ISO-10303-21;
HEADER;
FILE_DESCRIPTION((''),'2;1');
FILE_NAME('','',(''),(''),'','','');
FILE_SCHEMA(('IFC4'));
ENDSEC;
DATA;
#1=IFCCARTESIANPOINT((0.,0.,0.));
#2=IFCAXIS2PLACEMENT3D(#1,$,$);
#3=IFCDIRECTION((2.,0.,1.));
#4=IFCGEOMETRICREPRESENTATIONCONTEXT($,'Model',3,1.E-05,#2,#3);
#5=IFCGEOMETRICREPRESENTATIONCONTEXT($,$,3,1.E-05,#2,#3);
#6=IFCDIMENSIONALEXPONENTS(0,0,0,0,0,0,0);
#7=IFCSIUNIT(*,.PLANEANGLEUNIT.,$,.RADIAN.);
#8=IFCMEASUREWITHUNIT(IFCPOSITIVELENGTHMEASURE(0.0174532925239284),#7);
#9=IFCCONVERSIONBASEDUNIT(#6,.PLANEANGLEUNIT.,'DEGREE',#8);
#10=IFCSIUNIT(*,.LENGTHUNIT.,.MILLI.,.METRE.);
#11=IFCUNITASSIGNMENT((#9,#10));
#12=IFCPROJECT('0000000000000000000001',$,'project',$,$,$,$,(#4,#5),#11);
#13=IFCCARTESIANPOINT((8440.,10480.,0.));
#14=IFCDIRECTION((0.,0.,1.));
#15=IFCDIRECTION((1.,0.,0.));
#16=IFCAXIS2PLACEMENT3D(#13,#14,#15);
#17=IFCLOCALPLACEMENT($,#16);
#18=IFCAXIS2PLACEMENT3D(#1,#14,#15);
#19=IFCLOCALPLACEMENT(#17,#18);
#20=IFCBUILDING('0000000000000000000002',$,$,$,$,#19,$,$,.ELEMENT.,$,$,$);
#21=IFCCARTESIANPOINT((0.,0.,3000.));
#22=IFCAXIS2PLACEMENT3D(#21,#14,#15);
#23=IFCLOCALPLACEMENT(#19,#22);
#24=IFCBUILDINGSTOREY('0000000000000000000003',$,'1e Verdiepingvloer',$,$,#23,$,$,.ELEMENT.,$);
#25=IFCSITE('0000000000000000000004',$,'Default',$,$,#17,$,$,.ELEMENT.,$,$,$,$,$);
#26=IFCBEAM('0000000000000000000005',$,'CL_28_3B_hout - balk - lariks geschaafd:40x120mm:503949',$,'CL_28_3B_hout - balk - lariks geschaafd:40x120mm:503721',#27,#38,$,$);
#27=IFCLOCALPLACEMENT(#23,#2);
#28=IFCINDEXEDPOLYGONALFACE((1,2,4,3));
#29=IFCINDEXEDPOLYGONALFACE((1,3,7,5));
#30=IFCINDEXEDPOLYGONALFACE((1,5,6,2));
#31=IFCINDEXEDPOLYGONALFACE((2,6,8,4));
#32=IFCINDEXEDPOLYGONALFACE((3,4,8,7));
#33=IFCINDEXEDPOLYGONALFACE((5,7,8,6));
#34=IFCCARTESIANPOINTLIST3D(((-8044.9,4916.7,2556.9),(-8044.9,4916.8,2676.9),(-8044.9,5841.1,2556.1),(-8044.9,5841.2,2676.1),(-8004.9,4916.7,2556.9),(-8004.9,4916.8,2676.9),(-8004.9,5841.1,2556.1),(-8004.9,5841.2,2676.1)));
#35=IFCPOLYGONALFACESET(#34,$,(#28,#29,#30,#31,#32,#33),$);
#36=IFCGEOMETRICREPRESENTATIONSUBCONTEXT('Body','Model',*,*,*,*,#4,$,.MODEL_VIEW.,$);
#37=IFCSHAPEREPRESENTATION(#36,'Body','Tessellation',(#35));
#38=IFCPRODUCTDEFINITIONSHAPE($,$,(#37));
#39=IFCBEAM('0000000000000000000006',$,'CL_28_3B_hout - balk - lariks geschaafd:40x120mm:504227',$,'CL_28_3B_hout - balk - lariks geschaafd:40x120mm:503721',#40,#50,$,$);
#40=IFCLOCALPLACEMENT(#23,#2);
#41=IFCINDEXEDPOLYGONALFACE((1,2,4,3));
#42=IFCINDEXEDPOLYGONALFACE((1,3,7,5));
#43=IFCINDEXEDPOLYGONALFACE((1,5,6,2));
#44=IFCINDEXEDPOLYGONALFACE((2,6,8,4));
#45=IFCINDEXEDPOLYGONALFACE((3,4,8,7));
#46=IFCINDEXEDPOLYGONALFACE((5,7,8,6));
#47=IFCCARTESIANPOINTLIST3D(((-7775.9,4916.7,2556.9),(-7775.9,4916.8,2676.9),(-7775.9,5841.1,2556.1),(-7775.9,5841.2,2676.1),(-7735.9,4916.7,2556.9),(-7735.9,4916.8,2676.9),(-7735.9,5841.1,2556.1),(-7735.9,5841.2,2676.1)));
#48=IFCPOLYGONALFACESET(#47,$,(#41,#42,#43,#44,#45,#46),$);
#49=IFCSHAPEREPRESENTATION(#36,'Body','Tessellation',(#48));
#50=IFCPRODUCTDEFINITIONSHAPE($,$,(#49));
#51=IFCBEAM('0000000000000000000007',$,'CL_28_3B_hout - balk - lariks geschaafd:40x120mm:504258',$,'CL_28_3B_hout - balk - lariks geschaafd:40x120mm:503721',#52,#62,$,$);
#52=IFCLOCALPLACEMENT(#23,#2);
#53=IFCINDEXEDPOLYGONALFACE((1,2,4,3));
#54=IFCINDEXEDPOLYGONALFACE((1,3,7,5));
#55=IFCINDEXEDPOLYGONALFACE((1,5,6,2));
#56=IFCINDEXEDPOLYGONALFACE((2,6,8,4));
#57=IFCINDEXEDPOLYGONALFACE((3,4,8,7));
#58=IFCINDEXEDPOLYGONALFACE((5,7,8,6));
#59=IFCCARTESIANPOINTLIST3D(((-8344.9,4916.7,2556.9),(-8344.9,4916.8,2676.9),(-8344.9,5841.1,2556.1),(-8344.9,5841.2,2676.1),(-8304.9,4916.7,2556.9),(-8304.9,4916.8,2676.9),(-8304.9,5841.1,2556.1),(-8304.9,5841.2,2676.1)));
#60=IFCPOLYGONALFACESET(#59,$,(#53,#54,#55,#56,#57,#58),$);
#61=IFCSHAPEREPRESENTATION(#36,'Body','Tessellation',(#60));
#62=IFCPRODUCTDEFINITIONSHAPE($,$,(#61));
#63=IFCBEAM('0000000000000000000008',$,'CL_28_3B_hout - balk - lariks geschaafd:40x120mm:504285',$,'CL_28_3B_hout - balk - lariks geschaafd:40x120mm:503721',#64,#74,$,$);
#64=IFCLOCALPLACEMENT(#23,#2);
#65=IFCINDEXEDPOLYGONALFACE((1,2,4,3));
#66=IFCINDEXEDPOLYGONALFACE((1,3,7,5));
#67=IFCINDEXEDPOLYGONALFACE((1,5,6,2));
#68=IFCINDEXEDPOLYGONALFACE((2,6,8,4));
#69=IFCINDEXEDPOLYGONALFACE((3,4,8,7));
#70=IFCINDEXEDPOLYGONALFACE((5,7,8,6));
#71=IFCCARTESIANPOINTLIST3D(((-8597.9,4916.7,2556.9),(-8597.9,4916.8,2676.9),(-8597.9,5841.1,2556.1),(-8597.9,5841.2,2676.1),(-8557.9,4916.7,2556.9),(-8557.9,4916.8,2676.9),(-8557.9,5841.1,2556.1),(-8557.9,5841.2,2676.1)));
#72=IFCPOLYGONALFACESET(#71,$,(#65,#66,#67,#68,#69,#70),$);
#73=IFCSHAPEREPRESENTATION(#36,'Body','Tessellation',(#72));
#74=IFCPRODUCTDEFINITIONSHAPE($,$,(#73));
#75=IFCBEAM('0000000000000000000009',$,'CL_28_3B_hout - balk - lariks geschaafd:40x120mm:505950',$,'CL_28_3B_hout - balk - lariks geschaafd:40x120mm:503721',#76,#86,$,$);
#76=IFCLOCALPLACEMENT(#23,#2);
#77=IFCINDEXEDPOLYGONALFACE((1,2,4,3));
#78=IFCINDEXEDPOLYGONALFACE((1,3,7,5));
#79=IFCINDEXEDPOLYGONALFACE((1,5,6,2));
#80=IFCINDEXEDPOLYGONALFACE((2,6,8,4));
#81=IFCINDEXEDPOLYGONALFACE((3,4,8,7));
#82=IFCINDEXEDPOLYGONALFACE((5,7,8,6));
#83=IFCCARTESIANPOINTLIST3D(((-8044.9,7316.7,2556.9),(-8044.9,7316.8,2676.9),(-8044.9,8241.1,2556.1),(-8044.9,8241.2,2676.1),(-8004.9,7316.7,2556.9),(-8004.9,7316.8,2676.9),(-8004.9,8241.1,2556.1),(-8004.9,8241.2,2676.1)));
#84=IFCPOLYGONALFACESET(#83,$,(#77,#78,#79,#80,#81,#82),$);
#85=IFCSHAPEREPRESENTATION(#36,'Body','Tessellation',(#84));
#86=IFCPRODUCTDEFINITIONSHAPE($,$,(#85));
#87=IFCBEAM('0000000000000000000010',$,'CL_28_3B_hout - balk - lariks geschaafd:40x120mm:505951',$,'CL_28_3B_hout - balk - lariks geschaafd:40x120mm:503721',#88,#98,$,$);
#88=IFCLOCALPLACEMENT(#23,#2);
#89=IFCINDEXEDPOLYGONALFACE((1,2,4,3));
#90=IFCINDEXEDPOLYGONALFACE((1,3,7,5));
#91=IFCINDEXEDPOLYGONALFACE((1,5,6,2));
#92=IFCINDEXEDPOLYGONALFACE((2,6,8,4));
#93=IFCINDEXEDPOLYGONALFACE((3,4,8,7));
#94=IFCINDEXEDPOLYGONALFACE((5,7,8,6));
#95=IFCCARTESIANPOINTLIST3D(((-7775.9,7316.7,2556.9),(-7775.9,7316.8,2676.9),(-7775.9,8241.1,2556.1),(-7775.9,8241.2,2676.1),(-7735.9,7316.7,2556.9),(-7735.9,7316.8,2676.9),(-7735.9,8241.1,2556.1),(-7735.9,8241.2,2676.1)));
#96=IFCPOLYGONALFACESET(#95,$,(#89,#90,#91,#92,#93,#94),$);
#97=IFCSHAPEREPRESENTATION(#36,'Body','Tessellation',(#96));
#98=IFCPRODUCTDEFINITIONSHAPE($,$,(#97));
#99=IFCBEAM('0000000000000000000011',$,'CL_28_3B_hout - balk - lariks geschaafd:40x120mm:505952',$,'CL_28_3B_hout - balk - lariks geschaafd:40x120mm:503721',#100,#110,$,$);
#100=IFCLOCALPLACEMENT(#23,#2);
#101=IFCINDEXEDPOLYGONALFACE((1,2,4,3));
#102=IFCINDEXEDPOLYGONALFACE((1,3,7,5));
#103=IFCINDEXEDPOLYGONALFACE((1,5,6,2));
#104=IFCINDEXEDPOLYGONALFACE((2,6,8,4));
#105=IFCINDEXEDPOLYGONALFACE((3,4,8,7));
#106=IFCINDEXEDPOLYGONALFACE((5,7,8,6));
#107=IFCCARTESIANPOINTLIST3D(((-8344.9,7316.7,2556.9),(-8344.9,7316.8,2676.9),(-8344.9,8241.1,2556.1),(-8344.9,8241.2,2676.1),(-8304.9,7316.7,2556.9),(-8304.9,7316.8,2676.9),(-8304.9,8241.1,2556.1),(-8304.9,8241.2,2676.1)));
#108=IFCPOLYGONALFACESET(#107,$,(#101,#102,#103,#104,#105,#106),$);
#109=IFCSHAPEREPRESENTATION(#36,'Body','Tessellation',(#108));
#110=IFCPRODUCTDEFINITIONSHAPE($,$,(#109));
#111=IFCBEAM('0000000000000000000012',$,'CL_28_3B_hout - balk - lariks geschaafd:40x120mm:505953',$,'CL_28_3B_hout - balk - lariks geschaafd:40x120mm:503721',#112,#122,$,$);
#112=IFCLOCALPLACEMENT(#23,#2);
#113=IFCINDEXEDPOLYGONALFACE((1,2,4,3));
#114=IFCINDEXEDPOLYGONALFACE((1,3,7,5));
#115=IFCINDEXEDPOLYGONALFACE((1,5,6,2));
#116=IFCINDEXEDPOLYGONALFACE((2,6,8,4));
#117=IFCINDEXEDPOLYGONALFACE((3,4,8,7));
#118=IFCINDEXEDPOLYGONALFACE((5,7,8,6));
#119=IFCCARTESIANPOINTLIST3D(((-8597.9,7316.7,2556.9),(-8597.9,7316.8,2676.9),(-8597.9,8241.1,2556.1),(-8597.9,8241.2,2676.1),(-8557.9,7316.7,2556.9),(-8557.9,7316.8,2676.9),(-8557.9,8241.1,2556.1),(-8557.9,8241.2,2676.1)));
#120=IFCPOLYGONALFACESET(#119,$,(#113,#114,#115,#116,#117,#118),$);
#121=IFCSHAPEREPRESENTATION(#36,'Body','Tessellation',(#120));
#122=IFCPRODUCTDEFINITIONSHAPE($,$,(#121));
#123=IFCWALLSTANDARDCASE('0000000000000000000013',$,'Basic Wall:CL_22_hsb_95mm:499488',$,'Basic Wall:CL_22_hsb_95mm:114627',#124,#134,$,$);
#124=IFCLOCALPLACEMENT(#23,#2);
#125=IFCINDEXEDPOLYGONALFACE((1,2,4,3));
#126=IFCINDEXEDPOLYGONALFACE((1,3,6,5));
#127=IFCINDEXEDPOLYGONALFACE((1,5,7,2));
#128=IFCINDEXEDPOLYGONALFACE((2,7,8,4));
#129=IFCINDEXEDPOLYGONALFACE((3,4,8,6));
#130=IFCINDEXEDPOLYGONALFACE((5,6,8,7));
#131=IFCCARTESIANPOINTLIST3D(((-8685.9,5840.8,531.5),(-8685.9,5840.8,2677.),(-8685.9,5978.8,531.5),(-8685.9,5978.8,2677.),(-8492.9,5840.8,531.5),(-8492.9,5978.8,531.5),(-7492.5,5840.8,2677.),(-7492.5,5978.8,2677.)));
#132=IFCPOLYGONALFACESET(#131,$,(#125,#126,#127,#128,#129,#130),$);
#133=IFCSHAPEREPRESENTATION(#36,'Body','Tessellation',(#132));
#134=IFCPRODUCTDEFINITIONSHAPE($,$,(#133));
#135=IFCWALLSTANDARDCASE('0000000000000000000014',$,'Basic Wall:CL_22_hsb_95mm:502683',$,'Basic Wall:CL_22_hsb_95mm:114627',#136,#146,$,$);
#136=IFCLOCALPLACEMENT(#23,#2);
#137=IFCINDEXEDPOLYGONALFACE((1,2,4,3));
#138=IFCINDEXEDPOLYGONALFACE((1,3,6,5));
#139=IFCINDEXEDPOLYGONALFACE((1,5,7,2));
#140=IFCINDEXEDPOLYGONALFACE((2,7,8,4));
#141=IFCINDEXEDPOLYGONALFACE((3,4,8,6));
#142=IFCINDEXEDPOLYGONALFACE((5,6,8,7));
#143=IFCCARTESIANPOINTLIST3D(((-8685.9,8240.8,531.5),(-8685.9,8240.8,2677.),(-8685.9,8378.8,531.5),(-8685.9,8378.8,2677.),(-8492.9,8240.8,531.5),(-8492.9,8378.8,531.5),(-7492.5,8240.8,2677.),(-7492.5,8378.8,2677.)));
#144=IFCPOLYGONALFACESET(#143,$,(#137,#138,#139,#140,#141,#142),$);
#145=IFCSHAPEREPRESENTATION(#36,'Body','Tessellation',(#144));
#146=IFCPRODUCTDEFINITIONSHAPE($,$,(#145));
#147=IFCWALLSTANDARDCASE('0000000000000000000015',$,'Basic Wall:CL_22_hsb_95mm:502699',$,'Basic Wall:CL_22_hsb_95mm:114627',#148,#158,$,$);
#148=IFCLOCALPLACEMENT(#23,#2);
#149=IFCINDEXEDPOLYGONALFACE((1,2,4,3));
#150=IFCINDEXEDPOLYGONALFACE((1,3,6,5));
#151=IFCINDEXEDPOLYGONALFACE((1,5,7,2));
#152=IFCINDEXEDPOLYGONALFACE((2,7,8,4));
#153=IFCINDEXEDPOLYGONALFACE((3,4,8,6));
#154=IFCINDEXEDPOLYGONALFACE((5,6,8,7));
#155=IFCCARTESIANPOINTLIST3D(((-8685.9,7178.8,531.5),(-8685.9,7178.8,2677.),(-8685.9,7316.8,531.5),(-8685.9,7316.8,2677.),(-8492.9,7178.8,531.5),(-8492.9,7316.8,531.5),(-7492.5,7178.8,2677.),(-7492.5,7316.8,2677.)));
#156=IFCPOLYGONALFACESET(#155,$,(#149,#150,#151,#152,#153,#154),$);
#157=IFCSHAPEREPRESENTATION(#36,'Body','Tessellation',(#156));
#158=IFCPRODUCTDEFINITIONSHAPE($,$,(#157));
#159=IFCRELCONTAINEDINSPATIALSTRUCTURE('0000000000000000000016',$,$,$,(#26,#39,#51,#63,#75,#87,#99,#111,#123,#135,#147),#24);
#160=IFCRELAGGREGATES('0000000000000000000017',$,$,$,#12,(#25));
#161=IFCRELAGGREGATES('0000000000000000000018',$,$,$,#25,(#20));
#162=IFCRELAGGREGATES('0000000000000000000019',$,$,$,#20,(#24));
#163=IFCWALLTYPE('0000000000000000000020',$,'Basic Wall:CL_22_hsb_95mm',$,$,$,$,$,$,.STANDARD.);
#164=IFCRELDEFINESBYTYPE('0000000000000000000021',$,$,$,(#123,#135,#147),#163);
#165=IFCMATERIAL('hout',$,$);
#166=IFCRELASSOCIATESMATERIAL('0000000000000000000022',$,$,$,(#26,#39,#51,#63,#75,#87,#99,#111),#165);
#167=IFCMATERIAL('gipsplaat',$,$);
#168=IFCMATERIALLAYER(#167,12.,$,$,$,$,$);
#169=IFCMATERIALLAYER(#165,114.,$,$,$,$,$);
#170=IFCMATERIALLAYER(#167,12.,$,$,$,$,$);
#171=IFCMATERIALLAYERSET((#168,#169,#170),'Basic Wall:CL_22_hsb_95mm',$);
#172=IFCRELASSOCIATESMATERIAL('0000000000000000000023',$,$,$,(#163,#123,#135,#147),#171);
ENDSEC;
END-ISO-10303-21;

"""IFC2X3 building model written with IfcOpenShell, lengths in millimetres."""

from ifc_helpers import new_model, entity, si_unit, converted_unit, direction, frame, frame_2d, origin, origin_with_axes, place, context, subcontext, project, spatial, rectangle, extrude, clip, halfspace, source, transform, mapped, material, layer, layer_set, layer_usage, type_object, element, save


model = new_model("IFC2X3")

# Units and contexts
model_context = context("Model", 3, precision=1e-05, world=origin(), true_north=direction((2.0, 0.0, 1.0)))
context_of_model = context(None, 3, precision=1e-05, world=origin(), true_north=direction((2.0, 0.0, 1.0)))
body_context = subcontext(model_context, "Body", "Model", "MODEL_VIEW")
ifc_project = project(units=[converted_unit("PLANEANGLEUNIT", "DEGREE", entity("IfcPositiveLengthMeasure", 0.0174532925239284), si_unit("PLANEANGLEUNIT", "RADIAN"), dimensions=[0, 0, 0, 0, 0, 0, 0]), si_unit("LENGTHUNIT", "METRE", prefix="MILLI")], contexts=[model_context, context_of_model])

# Site, building, storey
site_placement = place(None, frame((8440.0, 10480.0, 0.0), z_axis=(0.0, 0.0, 1.0), x_axis=(1.0, 0.0, 0.0)))
site = spatial("IfcSite", under=ifc_project, at=site_placement, Name="Default", CompositionType="ELEMENT")
building_placement = place(site_placement, origin_with_axes())
building = spatial("IfcBuilding", under=site, at=building_placement, CompositionType="ELEMENT")
storey_placement = place(building_placement, frame((0.0, 0.0, 3000.0), z_axis=(0.0, 0.0, 1.0), x_axis=(1.0, 0.0, 0.0)))
storey = spatial("IfcBuildingStorey", under=building, at=storey_placement, Name="1e Verdiepingvloer", CompositionType="ELEMENT")

# Beams
ifc_material_1 = material(Name="hout")
shared_shape_1 = source(origin(), body_context, "Body", "SweptSolid", [
    extrude(rectangle(XDim=120.0, YDim=40.0, at=frame_2d((0.0, 0.0), x_axis=(1.0, 0.0))), frame((68.6, 0.0, -60.0), z_axis=(1.0, 0.0, 0.0), x_axis=(0.0, 0.0, -1.0)), (0.0, 0.0, 1.0), 924.4),
])
for number, where, z_axis, x_axis, name in (
    (1, (-8024.9, 5909.8, 2676.0), (0.0, 0.000942, 1.0), (0.0, -1.0, 0.000942), "CL_28_3B_hout - balk - lariks geschaafd:40x120mm:503949"),
    (2, (-7755.9, 5909.8, 2676.0), (0.0, 0.000942, 1.0), (0.0, -1.0, 0.000942), "CL_28_3B_hout - balk - lariks geschaafd:40x120mm:504227"),
    (3, (-8324.9, 5909.8, 2676.0), (0.0, 0.000942, 1.0), (0.0, -1.0, 0.000942), "CL_28_3B_hout - balk - lariks geschaafd:40x120mm:504258"),
    (4, (-8577.9, 5909.8, 2676.0), (0.0, 0.000942, 1.0), (0.0, -1.0, 0.000942), "CL_28_3B_hout - balk - lariks geschaafd:40x120mm:504285"),
    (5, (-8024.9, 8309.8, 2676.0), (0.0, 0.000942, 1.0), (0.0, -1.0, 0.000942), "CL_28_3B_hout - balk - lariks geschaafd:40x120mm:505950"),
    (6, (-7755.9, 8309.8, 2676.0), (0.0, 0.000942, 1.0), (0.0, -1.0, 0.000942), "CL_28_3B_hout - balk - lariks geschaafd:40x120mm:505951"),
    (7, (-8324.9, 8309.8, 2676.0), (0.0, 0.000942, 1.0), (0.0, -1.0, 0.000942), "CL_28_3B_hout - balk - lariks geschaafd:40x120mm:505952"),
    (8, (-8577.9, 8309.8, 2676.0), (0.0, 0.000942, 1.0), (0.0, -1.0, 0.000942), "CL_28_3B_hout - balk - lariks geschaafd:40x120mm:505953"),
):
    element("IfcBeam", number, at=place(storey_placement, frame(where, z_axis=z_axis, x_axis=x_axis)), inside=storey, material=ifc_material_1, Name=name, ObjectType="CL_28_3B_hout - balk - lariks geschaafd:40x120mm:503721", context=body_context, shape_type="MappedRepresentation", body=[
        mapped(shared_shape_1, transform((0.0, 0.0, 0.0))),
    ])

# Walls
ifc_material_2 = material(Name="gipsplaat")
ifc_layer_1 = layer(ifc_material_2, 12.0)
ifc_layer_2 = layer(ifc_material_1, 114.0)
ifc_layer_3 = layer(ifc_material_2, 12.0)
ifc_layer_set = layer_set([ifc_layer_1, ifc_layer_2, ifc_layer_3], Name="Basic Wall:CL_22_hsb_95mm")
ifc_layer_usage_1 = layer_usage(ifc_layer_set, "AXIS2", "POSITIVE", -69.0)
wall_type = type_object("IfcWallType", Name="Basic Wall:CL_22_hsb_95mm", PredefinedType="STANDARD", material=ifc_layer_set)
shared_shape_2 = source(origin(), body_context, "Body", "Clipping", [
    clip(clip(extrude(rectangle(XDim=1193.5, YDim=138.0, at=frame_2d((596.7, 0.0), x_axis=(-1.0, 0.0))), origin(), (0.0, 0.0, 1.0), 2677.0), halfspace(frame((1000.5, -69.0, 531.5), z_axis=(-0.906308, 0.0, -0.422618), x_axis=(0.0, 1.0, 0.0)), False)), halfspace(frame((1193.5, -69.0, 531.5), z_axis=(0.0, 0.0, -1.0), x_axis=(0.0, 1.0, 0.0)), False)),
])
wall_1_placement = place(storey_placement, frame((-7492.5, 5909.8, 0.0), z_axis=(0.0, 0.0, 1.0), x_axis=(-1.0, 0.0, 0.0)))
element("IfcWallStandardCase", 9, at=wall_1_placement, inside=storey, type_object=wall_type, material=ifc_layer_usage_1, Name="Basic Wall:CL_22_hsb_95mm:499488", ObjectType="Basic Wall:CL_22_hsb_95mm:114627", context=body_context, shape_type="MappedRepresentation", body=[
    mapped(shared_shape_2, transform((0.0, 0.0, 0.0))),
])
ifc_layer_usage_2 = layer_usage(ifc_layer_set, "AXIS2", "POSITIVE", -69.0)
wall_2_placement = place(storey_placement, frame((-7492.5, 8309.8, 0.0), z_axis=(0.0, 0.0, 1.0), x_axis=(-1.0, 0.0, 0.0)))
element("IfcWallStandardCase", 10, at=wall_2_placement, inside=storey, type_object=wall_type, material=ifc_layer_usage_2, Name="Basic Wall:CL_22_hsb_95mm:502683", ObjectType="Basic Wall:CL_22_hsb_95mm:114627", context=body_context, shape_type="MappedRepresentation", body=[
    mapped(shared_shape_2, transform((0.0, 0.0, 0.0))),
])
ifc_layer_usage_3 = layer_usage(ifc_layer_set, "AXIS2", "POSITIVE", -69.0)
wall_3_placement = place(storey_placement, frame((-7492.5, 7247.8, 0.0), z_axis=(0.0, 0.0, 1.0), x_axis=(-1.0, 0.0, 0.0)))
element("IfcWallStandardCase", 11, at=wall_3_placement, inside=storey, type_object=wall_type, material=ifc_layer_usage_3, Name="Basic Wall:CL_22_hsb_95mm:502699", ObjectType="Basic Wall:CL_22_hsb_95mm:114627", context=body_context, shape_type="MappedRepresentation", body=[
    mapped(shared_shape_2, transform((0.0, 0.0, 0.0))),
])

save(model, "model.ifc")
